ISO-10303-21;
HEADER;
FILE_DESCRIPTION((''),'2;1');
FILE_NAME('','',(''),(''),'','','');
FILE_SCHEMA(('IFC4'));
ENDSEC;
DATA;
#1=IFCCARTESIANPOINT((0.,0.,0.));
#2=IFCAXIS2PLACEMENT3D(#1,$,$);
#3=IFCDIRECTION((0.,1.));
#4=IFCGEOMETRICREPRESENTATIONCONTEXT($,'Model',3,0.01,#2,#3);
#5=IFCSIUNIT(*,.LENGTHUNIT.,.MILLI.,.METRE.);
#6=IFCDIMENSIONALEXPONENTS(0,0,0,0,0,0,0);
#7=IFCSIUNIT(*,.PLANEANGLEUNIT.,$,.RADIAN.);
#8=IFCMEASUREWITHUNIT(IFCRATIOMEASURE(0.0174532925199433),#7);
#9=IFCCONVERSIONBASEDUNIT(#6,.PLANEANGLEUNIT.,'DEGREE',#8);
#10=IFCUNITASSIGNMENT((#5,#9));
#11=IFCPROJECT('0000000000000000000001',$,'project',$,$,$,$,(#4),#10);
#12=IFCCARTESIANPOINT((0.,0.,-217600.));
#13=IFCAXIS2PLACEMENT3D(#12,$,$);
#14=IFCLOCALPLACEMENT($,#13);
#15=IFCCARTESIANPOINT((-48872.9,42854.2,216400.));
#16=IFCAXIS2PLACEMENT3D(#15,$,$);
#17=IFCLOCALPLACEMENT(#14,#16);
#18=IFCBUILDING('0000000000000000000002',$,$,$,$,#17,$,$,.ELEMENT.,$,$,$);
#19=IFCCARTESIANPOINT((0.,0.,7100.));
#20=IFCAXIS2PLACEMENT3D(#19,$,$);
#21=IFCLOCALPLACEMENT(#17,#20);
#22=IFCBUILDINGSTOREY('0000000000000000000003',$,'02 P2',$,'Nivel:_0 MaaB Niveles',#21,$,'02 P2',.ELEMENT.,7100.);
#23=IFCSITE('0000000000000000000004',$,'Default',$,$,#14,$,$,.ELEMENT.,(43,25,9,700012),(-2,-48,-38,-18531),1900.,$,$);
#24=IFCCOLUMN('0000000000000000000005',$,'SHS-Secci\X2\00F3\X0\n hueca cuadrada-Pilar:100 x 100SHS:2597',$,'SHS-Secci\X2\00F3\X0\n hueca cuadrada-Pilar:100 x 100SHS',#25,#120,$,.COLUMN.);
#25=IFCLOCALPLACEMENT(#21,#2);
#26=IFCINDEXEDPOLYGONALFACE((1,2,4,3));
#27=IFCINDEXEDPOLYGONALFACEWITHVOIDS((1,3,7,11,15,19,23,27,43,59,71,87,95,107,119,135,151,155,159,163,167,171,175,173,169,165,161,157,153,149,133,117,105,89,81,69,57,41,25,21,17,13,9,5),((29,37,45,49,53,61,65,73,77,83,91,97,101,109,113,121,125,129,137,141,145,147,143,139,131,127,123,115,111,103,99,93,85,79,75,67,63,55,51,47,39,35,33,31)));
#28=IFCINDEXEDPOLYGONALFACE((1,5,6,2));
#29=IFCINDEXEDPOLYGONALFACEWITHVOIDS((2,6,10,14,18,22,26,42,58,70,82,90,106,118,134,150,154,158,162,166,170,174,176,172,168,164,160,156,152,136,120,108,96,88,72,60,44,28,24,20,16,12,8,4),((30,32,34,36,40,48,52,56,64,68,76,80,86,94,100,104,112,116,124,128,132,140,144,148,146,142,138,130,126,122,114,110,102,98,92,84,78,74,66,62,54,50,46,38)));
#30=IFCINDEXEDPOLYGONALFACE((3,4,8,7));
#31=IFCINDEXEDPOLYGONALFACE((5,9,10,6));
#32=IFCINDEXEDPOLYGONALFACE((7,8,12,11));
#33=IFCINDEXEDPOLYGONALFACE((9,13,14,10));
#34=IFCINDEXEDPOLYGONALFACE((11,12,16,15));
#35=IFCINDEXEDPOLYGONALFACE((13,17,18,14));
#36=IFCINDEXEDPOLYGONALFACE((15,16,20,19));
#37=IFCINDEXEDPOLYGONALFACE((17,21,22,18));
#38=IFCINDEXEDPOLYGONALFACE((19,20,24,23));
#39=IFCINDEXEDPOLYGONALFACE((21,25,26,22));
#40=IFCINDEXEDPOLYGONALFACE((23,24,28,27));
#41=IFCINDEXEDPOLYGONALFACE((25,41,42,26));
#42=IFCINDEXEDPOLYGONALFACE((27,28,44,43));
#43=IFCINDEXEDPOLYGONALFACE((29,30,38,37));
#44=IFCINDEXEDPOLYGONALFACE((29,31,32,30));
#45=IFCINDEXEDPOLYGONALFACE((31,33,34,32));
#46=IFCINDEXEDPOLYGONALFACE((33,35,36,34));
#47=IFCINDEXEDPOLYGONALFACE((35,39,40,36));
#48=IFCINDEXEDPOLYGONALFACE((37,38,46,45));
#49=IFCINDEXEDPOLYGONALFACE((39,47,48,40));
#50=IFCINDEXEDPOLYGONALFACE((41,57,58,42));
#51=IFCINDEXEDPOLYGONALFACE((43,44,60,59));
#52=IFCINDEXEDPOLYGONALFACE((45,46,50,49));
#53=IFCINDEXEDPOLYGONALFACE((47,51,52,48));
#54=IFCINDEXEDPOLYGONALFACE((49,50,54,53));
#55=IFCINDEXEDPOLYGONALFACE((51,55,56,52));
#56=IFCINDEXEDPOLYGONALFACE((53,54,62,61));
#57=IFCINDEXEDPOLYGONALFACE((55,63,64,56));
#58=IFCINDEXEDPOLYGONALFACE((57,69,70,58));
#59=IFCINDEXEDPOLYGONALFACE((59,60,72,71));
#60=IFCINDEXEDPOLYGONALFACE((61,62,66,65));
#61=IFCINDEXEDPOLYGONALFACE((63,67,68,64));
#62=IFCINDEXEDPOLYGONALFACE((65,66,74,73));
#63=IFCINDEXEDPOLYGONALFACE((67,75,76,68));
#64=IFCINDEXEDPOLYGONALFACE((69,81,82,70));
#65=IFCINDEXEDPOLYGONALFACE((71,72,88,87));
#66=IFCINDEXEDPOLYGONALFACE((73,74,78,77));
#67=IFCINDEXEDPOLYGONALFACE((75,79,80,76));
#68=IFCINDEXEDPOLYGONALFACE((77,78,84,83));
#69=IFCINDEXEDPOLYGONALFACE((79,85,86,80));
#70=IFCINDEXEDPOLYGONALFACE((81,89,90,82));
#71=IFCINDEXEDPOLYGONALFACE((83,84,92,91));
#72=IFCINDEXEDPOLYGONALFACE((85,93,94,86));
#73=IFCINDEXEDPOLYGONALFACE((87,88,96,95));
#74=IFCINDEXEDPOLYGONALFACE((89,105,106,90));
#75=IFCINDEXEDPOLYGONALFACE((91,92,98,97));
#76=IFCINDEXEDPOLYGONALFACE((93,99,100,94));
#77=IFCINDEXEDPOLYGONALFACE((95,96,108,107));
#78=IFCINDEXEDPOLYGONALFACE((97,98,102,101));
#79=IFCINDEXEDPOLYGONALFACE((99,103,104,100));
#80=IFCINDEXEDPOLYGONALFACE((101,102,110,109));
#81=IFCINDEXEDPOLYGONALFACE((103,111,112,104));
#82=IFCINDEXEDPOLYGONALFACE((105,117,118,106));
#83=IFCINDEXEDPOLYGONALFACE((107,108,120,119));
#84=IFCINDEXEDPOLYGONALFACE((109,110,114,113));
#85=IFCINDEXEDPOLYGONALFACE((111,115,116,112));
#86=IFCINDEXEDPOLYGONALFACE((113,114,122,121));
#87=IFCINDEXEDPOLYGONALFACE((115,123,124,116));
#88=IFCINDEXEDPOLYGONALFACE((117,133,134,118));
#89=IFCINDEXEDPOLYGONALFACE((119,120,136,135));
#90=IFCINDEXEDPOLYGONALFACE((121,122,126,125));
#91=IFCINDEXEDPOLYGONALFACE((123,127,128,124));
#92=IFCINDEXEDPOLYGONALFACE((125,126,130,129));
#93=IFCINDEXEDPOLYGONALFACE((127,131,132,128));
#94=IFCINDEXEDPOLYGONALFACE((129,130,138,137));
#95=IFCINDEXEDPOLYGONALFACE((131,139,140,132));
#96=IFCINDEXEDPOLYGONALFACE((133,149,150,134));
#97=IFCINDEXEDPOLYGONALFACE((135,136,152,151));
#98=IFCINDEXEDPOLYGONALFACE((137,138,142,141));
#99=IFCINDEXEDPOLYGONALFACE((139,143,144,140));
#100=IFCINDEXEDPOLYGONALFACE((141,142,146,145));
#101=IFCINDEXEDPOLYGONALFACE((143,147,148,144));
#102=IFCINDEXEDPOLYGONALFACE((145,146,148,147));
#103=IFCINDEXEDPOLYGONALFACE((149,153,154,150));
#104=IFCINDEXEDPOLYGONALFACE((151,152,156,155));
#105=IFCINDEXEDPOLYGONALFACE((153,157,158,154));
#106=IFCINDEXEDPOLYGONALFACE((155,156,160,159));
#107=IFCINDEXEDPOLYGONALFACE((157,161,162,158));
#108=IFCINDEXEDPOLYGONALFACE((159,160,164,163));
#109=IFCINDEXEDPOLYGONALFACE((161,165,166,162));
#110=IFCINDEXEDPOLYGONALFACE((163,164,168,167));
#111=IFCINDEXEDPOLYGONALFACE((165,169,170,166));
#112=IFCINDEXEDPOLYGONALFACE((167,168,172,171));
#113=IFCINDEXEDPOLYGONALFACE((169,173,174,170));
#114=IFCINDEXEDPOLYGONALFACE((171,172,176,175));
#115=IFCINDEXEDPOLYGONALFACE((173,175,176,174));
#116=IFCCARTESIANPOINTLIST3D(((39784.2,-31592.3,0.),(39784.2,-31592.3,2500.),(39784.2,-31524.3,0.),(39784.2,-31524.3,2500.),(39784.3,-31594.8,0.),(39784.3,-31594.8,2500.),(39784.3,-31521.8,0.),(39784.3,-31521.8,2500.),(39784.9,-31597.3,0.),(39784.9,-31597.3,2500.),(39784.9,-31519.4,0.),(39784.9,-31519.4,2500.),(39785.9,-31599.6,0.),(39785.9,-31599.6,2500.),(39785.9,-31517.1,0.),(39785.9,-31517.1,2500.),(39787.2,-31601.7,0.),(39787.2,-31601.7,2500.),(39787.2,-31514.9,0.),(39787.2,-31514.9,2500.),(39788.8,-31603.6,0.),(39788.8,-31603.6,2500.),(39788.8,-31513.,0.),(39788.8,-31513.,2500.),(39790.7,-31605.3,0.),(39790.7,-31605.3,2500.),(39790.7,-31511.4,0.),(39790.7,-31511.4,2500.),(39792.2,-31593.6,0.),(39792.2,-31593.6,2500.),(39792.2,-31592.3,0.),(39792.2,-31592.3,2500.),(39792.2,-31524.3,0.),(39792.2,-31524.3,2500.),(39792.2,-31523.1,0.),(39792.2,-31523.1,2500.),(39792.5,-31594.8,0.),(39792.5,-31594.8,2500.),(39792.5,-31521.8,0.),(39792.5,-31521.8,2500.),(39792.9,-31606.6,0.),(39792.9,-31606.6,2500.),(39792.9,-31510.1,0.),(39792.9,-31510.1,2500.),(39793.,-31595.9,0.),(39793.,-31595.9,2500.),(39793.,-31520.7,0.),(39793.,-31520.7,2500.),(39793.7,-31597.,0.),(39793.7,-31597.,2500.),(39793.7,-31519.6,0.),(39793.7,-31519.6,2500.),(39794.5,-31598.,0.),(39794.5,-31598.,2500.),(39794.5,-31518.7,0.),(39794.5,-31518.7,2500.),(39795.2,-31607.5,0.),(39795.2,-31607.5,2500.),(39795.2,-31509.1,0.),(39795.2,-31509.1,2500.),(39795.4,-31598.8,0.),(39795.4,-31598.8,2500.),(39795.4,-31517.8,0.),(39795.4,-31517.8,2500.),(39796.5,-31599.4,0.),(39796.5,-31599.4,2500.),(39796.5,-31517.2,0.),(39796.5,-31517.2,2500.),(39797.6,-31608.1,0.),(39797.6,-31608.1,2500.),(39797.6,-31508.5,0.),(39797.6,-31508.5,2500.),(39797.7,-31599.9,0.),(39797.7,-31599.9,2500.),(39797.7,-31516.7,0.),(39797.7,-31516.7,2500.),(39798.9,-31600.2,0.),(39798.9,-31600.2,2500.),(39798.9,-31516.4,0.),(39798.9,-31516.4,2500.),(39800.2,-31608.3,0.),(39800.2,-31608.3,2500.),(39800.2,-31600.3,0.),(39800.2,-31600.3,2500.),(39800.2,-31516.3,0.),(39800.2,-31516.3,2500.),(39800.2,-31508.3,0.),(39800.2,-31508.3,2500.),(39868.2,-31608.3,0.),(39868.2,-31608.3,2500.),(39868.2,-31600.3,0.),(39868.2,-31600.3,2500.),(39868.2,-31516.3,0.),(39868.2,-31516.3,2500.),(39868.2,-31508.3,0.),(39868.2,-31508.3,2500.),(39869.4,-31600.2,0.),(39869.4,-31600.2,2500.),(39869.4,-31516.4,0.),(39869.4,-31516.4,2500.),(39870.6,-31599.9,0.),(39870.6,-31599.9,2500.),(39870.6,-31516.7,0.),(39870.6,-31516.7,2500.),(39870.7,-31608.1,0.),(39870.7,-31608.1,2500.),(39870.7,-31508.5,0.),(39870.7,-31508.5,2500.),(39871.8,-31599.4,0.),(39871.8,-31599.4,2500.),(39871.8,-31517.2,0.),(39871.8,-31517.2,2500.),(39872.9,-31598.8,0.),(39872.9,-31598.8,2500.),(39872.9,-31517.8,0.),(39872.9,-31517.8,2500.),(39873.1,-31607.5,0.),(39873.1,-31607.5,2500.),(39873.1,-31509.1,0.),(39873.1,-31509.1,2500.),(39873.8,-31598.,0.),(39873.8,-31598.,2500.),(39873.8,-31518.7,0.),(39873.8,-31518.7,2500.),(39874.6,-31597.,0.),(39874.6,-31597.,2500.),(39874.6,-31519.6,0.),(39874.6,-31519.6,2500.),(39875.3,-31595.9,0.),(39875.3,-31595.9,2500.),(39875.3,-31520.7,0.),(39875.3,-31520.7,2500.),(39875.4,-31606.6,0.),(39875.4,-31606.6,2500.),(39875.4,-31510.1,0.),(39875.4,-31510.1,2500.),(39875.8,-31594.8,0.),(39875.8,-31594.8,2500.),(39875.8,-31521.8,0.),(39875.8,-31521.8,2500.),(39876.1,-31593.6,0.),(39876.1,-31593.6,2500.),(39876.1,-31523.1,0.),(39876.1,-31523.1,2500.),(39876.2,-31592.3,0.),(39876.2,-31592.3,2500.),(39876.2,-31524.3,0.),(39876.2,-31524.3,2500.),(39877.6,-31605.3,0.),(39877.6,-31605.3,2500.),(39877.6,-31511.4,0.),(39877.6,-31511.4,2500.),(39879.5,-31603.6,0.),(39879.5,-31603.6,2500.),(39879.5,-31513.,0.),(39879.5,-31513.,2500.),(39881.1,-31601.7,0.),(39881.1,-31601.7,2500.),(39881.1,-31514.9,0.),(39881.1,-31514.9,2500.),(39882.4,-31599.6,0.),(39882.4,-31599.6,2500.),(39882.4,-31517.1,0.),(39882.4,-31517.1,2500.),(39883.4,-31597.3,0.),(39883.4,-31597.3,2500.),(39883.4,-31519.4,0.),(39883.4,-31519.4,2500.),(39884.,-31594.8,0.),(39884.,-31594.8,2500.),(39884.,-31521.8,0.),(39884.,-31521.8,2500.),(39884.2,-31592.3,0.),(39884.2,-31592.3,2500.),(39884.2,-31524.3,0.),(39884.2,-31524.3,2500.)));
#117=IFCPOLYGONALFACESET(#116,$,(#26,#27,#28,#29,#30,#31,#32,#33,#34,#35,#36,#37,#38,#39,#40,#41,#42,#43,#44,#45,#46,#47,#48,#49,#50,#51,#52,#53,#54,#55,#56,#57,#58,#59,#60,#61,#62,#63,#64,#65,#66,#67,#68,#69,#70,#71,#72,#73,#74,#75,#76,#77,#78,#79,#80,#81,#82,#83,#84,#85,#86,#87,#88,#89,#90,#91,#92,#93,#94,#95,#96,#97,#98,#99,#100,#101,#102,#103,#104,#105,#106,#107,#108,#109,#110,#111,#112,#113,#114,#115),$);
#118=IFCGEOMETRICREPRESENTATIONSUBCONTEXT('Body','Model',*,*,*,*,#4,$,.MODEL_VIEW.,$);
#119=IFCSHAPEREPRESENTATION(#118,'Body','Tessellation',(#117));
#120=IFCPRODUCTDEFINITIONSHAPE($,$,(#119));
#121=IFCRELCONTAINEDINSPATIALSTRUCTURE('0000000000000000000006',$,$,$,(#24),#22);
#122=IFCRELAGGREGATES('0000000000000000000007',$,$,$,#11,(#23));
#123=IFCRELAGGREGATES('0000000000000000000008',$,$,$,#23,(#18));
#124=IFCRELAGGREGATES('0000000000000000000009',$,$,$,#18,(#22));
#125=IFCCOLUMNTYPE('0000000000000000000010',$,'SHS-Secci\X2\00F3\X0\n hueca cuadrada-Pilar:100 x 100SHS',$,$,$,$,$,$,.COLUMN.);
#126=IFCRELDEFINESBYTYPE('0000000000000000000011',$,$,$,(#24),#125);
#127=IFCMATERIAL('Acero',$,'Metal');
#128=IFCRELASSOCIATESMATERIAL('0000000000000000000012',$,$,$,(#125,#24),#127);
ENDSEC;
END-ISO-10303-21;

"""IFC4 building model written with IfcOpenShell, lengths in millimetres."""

from ifc_helpers import new_model, entity, si_unit, converted_unit, direction, frame, origin, place, context, subcontext, project, spatial, indexed_curve, outline, extrude, source, transform, mapped, material, type_object, type_shapes, element, save


model = new_model("IFC4")

# Units and contexts
model_context = context("Model", 3, precision=0.01, world=origin(), true_north=direction((0.0, 1.0)))
body_context = subcontext(model_context, "Body", "Model", "MODEL_VIEW")
ifc_project = project(units=[si_unit("LENGTHUNIT", "METRE", prefix="MILLI"), converted_unit("PLANEANGLEUNIT", "DEGREE", entity("IfcRatioMeasure", 0.0174532925199433), si_unit("PLANEANGLEUNIT", "RADIAN"), dimensions=[0, 0, 0, 0, 0, 0, 0])], contexts=[model_context])

# Site, building, storey
site_placement = place(None, frame((0.0, 0.0, -217600.0)))
site = spatial("IfcSite", under=ifc_project, at=site_placement, Name="Default", CompositionType="ELEMENT", RefLatitude=(43, 25, 9, 700012), RefLongitude=(-2, -48, -38, -18531), RefElevation=1900.0)
building_placement = place(site_placement, frame((-48872.9, 42854.2, 216400.0)))
building = spatial("IfcBuilding", under=site, at=building_placement, CompositionType="ELEMENT")
storey_placement = place(building_placement, frame((0.0, 0.0, 7100.0)))
storey = spatial("IfcBuildingStorey", under=building, at=storey_placement, Name="02 P2", ObjectType="Nivel:_0 MaaB Niveles", LongName="02 P2", CompositionType="ELEMENT", Elevation=7100.0)

# Column
ifc_material_1 = material(Name="Acero", Category="Metal")
column_type_1 = type_object("IfcColumnType", Name="SHS-Sección hueca cuadrada-Pilar:100 x 100SHS", PredefinedType="COLUMN", material=ifc_material_1)
shared_shape_1 = source(origin(), body_context, "Body", "SweptSolid", [
    extrude(outline(indexed_curve([(-34.0, -50.0), (34.0, -50.0), (36.5, -49.8), (38.9, -49.2), (41.3, -48.3), (43.4, -46.9), (45.3, -45.3), (46.9, -43.4), (48.3, -41.3), (49.2, -38.9), (49.8, -36.5), (50.0, -34.0), (50.0, 34.0), (49.8, 36.5), (49.2, 38.9), (48.3, 41.3), (46.9, 43.4), (45.3, 45.3), (43.4, 46.9), (41.3, 48.3), (38.9, 49.2), (36.5, 49.8), (34.0, 50.0), (-34.0, 50.0), (-36.5, 49.8), (-38.9, 49.2), (-41.3, 48.3), (-43.4, 46.9), (-45.3, 45.3), (-46.9, 43.4), (-48.3, 41.3), (-49.2, 38.9), (-49.8, 36.5), (-50.0, 34.0), (-50.0, -34.0), (-49.8, -36.5), (-49.2, -38.9), (-48.3, -41.3), (-46.9, -43.4), (-45.3, -45.3), (-43.4, -46.9), (-41.3, -48.3), (-38.9, -49.2), (-36.5, -49.8), (-34.0, -50.0)], self_intersect=False), holes=[indexed_curve([(-34.0, -42.0), (-35.3, -41.9), (-36.5, -41.6), (-37.6, -41.1), (-38.7, -40.5), (-39.7, -39.7), (-40.5, -38.7), (-41.1, -37.6), (-41.6, -36.5), (-41.9, -35.3), (-42.0, -34.0), (-42.0, 34.0), (-41.9, 35.3), (-41.6, 36.5), (-41.1, 37.6), (-40.5, 38.7), (-39.7, 39.7), (-38.7, 40.5), (-37.6, 41.1), (-36.5, 41.6), (-35.3, 41.9), (-34.0, 42.0), (34.0, 42.0), (35.3, 41.9), (36.5, 41.6), (37.6, 41.1), (38.7, 40.5), (39.7, 39.7), (40.5, 38.7), (41.1, 37.6), (41.6, 36.5), (41.9, 35.3), (42.0, 34.0), (42.0, -34.0), (41.9, -35.3), (41.6, -36.5), (41.1, -37.6), (40.5, -38.7), (39.7, -39.7), (38.7, -40.5), (37.6, -41.1), (36.5, -41.6), (35.3, -41.9), (34.0, -42.0), (-34.0, -42.0)], self_intersect=False)]), frame((0.0, 0.0, 7100.0), z_axis=(0.0, 0.0, 1.0), x_axis=(-1.0, 0.0, 0.0)), (0.0, 0.0, 1.0), 2500.0),
])
type_shapes(column_type_1, [shared_shape_1])
column_1_placement = place(storey_placement, frame((39834.2, -31558.3, -7100.0), z_axis=(0.0, 0.0, 1.0), x_axis=(0.0, -1.0, 0.0)))
element("IfcColumn", 1, at=column_1_placement, inside=storey, type_object=column_type_1, material=ifc_material_1, Name="SHS-Sección hueca cuadrada-Pilar:100 x 100SHS:2597", ObjectType="SHS-Sección hueca cuadrada-Pilar:100 x 100SHS", PredefinedType="COLUMN", context=body_context, shape_type="MappedRepresentation", body=[
    mapped(shared_shape_1, transform((0.0, 0.0, 0.0), scale=1.0)),
])

save(model, "model.ifc")
